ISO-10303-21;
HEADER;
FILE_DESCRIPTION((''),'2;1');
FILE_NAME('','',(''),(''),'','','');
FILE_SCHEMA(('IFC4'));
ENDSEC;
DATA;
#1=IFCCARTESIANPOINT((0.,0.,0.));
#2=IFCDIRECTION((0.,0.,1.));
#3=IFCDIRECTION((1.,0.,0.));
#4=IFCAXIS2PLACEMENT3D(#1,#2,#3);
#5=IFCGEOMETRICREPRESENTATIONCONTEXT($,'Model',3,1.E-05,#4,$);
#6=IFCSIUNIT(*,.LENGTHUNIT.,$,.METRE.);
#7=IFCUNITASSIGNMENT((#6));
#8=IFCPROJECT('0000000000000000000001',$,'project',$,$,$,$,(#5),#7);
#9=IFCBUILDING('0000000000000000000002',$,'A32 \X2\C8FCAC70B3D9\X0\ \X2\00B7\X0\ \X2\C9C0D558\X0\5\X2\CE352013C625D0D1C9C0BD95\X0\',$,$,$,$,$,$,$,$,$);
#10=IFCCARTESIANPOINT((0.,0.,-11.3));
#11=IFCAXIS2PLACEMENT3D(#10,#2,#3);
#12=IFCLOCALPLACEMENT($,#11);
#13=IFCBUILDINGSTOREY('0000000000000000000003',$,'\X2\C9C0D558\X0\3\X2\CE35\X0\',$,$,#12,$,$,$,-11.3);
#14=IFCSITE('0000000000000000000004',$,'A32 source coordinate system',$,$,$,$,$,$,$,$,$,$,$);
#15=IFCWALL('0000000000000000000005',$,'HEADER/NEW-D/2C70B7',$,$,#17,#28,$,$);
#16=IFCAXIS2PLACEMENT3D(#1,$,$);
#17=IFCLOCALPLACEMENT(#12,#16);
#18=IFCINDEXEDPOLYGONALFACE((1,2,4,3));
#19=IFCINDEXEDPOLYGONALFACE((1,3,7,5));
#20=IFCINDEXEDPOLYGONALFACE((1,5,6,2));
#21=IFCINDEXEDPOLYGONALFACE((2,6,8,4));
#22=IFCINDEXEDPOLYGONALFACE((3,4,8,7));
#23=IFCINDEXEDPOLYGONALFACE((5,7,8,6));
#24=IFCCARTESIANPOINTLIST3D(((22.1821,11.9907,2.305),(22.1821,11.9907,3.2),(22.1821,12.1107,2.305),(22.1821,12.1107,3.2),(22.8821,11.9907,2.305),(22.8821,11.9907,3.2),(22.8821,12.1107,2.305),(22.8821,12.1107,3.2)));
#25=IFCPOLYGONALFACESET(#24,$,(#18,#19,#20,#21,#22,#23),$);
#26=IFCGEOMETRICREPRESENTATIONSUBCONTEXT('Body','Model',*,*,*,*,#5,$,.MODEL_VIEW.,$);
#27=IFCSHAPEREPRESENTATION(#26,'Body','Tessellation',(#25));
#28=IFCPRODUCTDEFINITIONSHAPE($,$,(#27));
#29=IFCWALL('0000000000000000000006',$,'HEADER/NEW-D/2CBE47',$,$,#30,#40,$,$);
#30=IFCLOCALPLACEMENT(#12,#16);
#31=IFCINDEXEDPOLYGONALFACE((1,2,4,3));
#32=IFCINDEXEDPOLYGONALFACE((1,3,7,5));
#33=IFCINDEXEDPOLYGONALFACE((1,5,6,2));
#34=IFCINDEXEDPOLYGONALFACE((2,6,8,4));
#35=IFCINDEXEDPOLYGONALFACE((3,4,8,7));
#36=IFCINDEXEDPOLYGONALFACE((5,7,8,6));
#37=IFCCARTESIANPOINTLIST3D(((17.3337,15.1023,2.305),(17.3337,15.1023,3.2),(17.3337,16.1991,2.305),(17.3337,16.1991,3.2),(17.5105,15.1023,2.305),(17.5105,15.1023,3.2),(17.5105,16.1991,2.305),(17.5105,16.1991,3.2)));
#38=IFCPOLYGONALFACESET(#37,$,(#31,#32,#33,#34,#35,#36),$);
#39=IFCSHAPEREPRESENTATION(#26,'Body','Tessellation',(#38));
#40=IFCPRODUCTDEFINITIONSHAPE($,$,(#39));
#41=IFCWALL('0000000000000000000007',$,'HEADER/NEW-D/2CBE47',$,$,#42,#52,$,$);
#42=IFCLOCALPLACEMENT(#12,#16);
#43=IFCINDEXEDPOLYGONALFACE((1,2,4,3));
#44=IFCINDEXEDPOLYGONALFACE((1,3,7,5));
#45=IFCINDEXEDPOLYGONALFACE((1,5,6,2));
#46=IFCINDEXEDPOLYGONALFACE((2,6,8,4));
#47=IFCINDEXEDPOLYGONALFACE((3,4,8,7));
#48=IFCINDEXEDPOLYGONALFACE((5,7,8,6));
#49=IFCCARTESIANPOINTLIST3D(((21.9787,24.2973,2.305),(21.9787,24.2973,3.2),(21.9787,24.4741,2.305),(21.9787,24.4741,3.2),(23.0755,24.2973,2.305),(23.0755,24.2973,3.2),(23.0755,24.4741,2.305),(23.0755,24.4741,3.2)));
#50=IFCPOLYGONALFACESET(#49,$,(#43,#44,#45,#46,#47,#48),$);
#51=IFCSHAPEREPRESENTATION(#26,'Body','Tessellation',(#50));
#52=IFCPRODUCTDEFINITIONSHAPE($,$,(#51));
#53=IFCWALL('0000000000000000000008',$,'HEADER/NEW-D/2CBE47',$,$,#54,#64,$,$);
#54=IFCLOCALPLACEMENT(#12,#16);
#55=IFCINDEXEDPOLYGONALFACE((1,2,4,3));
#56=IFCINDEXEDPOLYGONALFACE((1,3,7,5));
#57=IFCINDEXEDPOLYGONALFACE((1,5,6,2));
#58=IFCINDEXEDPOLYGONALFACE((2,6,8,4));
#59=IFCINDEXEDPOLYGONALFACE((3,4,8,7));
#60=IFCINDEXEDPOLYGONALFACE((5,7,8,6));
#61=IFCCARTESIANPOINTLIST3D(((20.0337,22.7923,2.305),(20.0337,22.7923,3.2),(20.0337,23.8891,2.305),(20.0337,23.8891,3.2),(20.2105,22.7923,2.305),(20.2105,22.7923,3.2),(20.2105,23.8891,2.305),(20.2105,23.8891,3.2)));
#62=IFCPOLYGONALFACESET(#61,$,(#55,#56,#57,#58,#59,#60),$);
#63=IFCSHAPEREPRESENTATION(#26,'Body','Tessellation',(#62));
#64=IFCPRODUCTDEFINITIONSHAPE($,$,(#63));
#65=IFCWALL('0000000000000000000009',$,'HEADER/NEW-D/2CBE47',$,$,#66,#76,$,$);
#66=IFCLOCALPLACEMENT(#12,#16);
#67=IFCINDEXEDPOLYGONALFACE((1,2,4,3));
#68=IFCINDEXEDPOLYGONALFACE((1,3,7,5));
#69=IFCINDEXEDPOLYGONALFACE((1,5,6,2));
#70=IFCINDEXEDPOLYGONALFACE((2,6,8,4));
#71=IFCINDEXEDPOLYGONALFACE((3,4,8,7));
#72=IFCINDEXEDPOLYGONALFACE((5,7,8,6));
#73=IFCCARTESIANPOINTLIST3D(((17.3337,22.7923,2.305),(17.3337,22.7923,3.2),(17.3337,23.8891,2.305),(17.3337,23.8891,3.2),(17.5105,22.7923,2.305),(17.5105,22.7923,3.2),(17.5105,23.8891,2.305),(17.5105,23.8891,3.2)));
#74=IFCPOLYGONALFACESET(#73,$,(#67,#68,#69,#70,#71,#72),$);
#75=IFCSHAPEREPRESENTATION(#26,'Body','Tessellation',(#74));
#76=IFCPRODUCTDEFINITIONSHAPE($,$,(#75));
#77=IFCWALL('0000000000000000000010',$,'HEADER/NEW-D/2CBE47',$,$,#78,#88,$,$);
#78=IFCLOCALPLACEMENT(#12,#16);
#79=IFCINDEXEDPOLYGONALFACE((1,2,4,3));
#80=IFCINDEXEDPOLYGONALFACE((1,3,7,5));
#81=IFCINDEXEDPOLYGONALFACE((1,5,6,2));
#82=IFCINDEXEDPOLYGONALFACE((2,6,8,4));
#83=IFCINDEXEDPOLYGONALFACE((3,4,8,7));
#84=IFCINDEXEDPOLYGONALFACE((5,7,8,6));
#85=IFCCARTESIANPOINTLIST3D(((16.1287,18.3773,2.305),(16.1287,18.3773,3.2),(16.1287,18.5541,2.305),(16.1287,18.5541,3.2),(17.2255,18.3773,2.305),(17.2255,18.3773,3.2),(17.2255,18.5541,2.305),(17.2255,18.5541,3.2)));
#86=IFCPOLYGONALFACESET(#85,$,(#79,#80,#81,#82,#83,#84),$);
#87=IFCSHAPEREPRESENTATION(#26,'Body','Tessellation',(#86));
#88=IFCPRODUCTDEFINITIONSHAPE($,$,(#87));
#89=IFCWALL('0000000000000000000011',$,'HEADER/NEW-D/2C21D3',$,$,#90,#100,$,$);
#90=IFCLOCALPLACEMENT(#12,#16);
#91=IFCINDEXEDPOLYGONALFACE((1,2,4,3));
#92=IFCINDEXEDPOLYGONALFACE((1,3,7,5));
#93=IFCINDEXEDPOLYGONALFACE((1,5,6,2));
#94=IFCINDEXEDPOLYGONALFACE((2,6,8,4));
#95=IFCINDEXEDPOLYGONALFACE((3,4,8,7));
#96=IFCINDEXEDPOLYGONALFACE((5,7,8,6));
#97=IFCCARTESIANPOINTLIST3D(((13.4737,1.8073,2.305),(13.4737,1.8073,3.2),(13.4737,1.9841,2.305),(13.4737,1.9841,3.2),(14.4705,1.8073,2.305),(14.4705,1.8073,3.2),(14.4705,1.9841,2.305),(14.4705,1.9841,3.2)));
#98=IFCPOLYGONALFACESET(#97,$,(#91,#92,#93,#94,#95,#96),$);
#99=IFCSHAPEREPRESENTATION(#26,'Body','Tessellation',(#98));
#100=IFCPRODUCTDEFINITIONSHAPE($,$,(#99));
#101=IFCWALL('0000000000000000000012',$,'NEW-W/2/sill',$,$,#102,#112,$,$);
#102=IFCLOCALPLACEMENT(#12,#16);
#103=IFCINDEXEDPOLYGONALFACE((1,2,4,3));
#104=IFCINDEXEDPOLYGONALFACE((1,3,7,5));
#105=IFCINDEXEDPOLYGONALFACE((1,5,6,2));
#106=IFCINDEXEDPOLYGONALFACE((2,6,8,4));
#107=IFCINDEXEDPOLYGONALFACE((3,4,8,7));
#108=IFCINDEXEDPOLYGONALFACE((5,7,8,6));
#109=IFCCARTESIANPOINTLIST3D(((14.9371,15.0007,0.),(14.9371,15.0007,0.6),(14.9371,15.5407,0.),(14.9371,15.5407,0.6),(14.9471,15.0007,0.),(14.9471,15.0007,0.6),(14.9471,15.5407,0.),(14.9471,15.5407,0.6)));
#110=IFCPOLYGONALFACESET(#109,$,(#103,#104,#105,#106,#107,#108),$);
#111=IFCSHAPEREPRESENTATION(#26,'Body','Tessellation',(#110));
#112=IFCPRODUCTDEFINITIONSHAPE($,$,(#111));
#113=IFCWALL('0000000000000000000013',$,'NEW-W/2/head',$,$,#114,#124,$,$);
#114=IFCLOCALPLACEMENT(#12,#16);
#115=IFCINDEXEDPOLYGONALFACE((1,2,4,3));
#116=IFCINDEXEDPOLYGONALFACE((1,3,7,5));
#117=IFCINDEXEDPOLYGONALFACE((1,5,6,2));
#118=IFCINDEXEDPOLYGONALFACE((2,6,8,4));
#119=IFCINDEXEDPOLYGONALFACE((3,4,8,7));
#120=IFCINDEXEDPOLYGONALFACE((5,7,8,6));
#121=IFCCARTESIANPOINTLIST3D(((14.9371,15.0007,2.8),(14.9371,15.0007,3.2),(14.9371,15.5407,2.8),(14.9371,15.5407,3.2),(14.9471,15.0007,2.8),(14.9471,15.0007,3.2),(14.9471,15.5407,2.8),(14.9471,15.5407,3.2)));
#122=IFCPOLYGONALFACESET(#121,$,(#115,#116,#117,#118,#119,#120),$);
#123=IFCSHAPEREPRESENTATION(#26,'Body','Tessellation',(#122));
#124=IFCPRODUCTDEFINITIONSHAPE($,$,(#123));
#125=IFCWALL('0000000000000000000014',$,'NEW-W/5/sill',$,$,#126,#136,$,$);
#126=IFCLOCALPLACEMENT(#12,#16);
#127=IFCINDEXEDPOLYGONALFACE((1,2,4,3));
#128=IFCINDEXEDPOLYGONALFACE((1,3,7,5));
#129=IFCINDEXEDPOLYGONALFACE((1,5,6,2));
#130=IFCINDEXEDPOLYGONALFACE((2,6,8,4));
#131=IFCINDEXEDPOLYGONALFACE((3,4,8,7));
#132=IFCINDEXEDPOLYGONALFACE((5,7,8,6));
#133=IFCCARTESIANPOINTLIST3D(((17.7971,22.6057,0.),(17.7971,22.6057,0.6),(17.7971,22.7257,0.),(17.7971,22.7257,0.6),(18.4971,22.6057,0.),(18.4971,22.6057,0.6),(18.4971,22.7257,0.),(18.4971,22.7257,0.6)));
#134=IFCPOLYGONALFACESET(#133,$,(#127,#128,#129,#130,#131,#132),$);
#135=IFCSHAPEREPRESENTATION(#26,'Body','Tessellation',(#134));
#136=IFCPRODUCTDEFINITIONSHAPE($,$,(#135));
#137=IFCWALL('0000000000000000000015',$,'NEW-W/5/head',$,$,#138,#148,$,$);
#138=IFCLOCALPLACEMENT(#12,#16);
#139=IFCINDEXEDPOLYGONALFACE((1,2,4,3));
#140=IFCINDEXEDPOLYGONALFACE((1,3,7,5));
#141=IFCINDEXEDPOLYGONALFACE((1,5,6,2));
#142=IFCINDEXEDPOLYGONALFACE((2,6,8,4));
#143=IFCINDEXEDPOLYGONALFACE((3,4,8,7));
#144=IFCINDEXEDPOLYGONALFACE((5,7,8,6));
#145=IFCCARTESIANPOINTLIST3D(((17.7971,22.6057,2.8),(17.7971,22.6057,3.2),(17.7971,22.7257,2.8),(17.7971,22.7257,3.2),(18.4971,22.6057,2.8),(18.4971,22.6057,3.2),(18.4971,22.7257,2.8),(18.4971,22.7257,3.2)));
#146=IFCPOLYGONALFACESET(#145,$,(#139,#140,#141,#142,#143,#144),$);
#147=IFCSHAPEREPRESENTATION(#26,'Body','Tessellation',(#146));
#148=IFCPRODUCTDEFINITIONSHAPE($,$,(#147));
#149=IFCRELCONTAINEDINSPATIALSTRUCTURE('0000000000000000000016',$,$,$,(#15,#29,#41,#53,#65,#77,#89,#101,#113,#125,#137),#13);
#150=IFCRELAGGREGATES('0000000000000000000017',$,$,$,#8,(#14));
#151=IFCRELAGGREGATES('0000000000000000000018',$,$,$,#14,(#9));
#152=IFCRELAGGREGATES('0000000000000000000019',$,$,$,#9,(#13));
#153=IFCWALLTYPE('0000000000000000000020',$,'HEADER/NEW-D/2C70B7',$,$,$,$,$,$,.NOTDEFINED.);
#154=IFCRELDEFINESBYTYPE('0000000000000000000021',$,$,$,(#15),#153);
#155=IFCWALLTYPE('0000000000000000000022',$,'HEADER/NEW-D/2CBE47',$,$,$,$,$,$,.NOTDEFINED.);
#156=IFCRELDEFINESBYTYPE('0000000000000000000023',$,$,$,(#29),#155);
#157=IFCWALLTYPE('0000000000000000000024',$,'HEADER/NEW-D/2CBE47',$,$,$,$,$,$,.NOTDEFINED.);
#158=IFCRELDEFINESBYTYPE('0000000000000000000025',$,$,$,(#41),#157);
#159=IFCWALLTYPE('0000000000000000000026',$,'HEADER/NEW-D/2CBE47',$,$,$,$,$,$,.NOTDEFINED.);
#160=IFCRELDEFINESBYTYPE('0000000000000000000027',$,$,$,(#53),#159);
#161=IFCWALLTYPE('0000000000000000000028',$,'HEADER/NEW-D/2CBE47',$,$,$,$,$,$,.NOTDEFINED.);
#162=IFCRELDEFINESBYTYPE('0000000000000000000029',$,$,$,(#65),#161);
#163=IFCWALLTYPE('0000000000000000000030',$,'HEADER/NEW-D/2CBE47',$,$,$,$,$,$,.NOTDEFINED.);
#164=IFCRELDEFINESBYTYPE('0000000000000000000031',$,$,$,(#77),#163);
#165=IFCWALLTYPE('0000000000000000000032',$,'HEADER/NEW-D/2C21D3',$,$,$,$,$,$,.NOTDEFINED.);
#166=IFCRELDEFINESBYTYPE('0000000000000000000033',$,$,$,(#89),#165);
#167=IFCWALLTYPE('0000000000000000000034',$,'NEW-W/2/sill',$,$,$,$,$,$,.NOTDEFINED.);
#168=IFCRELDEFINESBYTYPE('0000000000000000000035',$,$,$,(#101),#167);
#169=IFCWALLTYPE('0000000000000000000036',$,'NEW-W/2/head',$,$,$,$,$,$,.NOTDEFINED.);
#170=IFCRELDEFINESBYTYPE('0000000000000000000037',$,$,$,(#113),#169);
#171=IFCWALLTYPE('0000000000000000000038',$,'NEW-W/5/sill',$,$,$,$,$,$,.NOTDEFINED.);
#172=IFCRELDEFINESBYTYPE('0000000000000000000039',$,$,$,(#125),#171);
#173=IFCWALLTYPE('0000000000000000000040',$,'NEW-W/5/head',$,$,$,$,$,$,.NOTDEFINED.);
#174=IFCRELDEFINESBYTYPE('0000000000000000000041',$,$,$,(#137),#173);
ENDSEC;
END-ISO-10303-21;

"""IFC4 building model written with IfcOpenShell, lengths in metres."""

from ifc_helpers import new_model, si_unit, frame, origin, origin_with_axes, place, context, subcontext, project, spatial, polyline, outline, extrude, source, transform, mapped, type_object, type_shapes, element, save


model = new_model("IFC4")

# Units and contexts
model_context = context("Model", 3, precision=1e-05, world=origin_with_axes())
body_context = subcontext(model_context, "Body", "Model", "MODEL_VIEW")
ifc_project = project(units=[si_unit("LENGTHUNIT", "METRE")], contexts=[model_context])

# Site, building, storey
site = spatial("IfcSite", under=ifc_project, Name="A32 source coordinate system")
building = spatial("IfcBuilding", under=site, Name="A32 주거동 · 지하5층–옥탑지붕")
storey_placement = place(None, frame((0.0, 0.0, -11.3), z_axis=(0.0, 0.0, 1.0), x_axis=(1.0, 0.0, 0.0)))
storey = spatial("IfcBuildingStorey", under=building, at=storey_placement, Name="지하3층", Elevation=-11.3)

# Walls
wall_type_1 = type_object("IfcWallType", Name="HEADER/NEW-D/2C70B7", PredefinedType="NOTDEFINED")
shared_shape_1 = source(origin(), body_context, "Body", "SweptSolid", [
    extrude(outline(polyline([(22.1821, 11.9907), (22.1821, 12.1107), (22.8821, 12.1107), (22.8821, 11.9907), (22.1821, 11.9907)])), frame((0.0, 0.0, 2.305)), (0.0, 0.0, 1.0), 0.895),
])
type_shapes(wall_type_1, [shared_shape_1])
wall_1_placement = place(storey_placement, origin_with_axes())
element("IfcWall", 1, at=wall_1_placement, inside=storey, type_object=wall_type_1, Name="HEADER/NEW-D/2C70B7", context=body_context, shape_type="MappedRepresentation", body=[
    mapped(shared_shape_1, transform((0.0, 0.0, 0.0), scale=1.0)),
])
wall_type_2 = type_object("IfcWallType", Name="HEADER/NEW-D/2CBE47", PredefinedType="NOTDEFINED")
shared_shape_2 = source(origin(), body_context, "Body", "SweptSolid", [
    extrude(outline(polyline([(17.3337, 15.1023), (17.3337, 16.1991), (17.5105, 16.1991), (17.5105, 15.1023), (17.3337, 15.1023)])), frame((0.0, 0.0, 2.305)), (0.0, 0.0, 1.0), 0.895),
])
type_shapes(wall_type_2, [shared_shape_2])
wall_2_placement = place(storey_placement, origin_with_axes())
element("IfcWall", 2, at=wall_2_placement, inside=storey, type_object=wall_type_2, Name="HEADER/NEW-D/2CBE47", context=body_context, shape_type="MappedRepresentation", body=[
    mapped(shared_shape_2, transform((0.0, 0.0, 0.0), scale=1.0)),
])
wall_type_3 = type_object("IfcWallType", Name="HEADER/NEW-D/2CBE47", PredefinedType="NOTDEFINED")
shared_shape_3 = source(origin(), body_context, "Body", "SweptSolid", [
    extrude(outline(polyline([(21.9787, 24.2973), (21.9787, 24.4741), (23.0755, 24.4741), (23.0755, 24.2973), (21.9787, 24.2973)])), frame((0.0, 0.0, 2.305)), (0.0, 0.0, 1.0), 0.895),
])
type_shapes(wall_type_3, [shared_shape_3])
wall_3_placement = place(storey_placement, origin_with_axes())
element("IfcWall", 3, at=wall_3_placement, inside=storey, type_object=wall_type_3, Name="HEADER/NEW-D/2CBE47", context=body_context, shape_type="MappedRepresentation", body=[
    mapped(shared_shape_3, transform((0.0, 0.0, 0.0), scale=1.0)),
])
wall_type_4 = type_object("IfcWallType", Name="HEADER/NEW-D/2CBE47", PredefinedType="NOTDEFINED")
shared_shape_4 = source(origin(), body_context, "Body", "SweptSolid", [
    extrude(outline(polyline([(20.0337, 22.7923), (20.0337, 23.8891), (20.2105, 23.8891), (20.2105, 22.7923), (20.0337, 22.7923)])), frame((0.0, 0.0, 2.305)), (0.0, 0.0, 1.0), 0.895),
])
type_shapes(wall_type_4, [shared_shape_4])
wall_4_placement = place(storey_placement, origin_with_axes())
element("IfcWall", 4, at=wall_4_placement, inside=storey, type_object=wall_type_4, Name="HEADER/NEW-D/2CBE47", context=body_context, shape_type="MappedRepresentation", body=[
    mapped(shared_shape_4, transform((0.0, 0.0, 0.0), scale=1.0)),
])
wall_type_5 = type_object("IfcWallType", Name="HEADER/NEW-D/2CBE47", PredefinedType="NOTDEFINED")
shared_shape_5 = source(origin(), body_context, "Body", "SweptSolid", [
    extrude(outline(polyline([(17.3337, 22.7923), (17.3337, 23.8891), (17.5105, 23.8891), (17.5105, 22.7923), (17.3337, 22.7923)])), frame((0.0, 0.0, 2.305)), (0.0, 0.0, 1.0), 0.895),
])
type_shapes(wall_type_5, [shared_shape_5])
wall_5_placement = place(storey_placement, origin_with_axes())
element("IfcWall", 5, at=wall_5_placement, inside=storey, type_object=wall_type_5, Name="HEADER/NEW-D/2CBE47", context=body_context, shape_type="MappedRepresentation", body=[
    mapped(shared_shape_5, transform((0.0, 0.0, 0.0), scale=1.0)),
])
wall_type_6 = type_object("IfcWallType", Name="HEADER/NEW-D/2CBE47", PredefinedType="NOTDEFINED")
shared_shape_6 = source(origin(), body_context, "Body", "SweptSolid", [
    extrude(outline(polyline([(16.1287, 18.3773), (16.1287, 18.5541), (17.2255, 18.5541), (17.2255, 18.3773), (16.1287, 18.3773)])), frame((0.0, 0.0, 2.305)), (0.0, 0.0, 1.0), 0.895),
])
type_shapes(wall_type_6, [shared_shape_6])
wall_6_placement = place(storey_placement, origin_with_axes())
element("IfcWall", 6, at=wall_6_placement, inside=storey, type_object=wall_type_6, Name="HEADER/NEW-D/2CBE47", context=body_context, shape_type="MappedRepresentation", body=[
    mapped(shared_shape_6, transform((0.0, 0.0, 0.0), scale=1.0)),
])
wall_type_7 = type_object("IfcWallType", Name="HEADER/NEW-D/2C21D3", PredefinedType="NOTDEFINED")
shared_shape_7 = source(origin(), body_context, "Body", "SweptSolid", [
    extrude(outline(polyline([(13.4737, 1.8073), (13.4737, 1.9841), (14.4705, 1.9841), (14.4705, 1.8073), (13.4737, 1.8073)])), frame((0.0, 0.0, 2.305)), (0.0, 0.0, 1.0), 0.895),
])
type_shapes(wall_type_7, [shared_shape_7])
wall_7_placement = place(storey_placement, origin_with_axes())
element("IfcWall", 7, at=wall_7_placement, inside=storey, type_object=wall_type_7, Name="HEADER/NEW-D/2C21D3", context=body_context, shape_type="MappedRepresentation", body=[
    mapped(shared_shape_7, transform((0.0, 0.0, 0.0), scale=1.0)),
])
wall_type_8 = type_object("IfcWallType", Name="NEW-W/2/sill", PredefinedType="NOTDEFINED")
shared_shape_8 = source(origin(), body_context, "Body", "SweptSolid", [
    extrude(outline(polyline([(14.9471, 15.5407), (14.9471, 15.0007), (14.9371, 15.0007), (14.9371, 15.5407), (14.9471, 15.5407)])), origin(), (0.0, 0.0, 1.0), 0.6),
])
type_shapes(wall_type_8, [shared_shape_8])
wall_8_placement = place(storey_placement, origin_with_axes())
element("IfcWall", 8, at=wall_8_placement, inside=storey, type_object=wall_type_8, Name="NEW-W/2/sill", context=body_context, shape_type="MappedRepresentation", body=[
    mapped(shared_shape_8, transform((0.0, 0.0, 0.0), scale=1.0)),
])
wall_type_9 = type_object("IfcWallType", Name="NEW-W/2/head", PredefinedType="NOTDEFINED")
shared_shape_9 = source(origin(), body_context, "Body", "SweptSolid", [
    extrude(outline(polyline([(14.9471, 15.5407), (14.9471, 15.0007), (14.9371, 15.0007), (14.9371, 15.5407), (14.9471, 15.5407)])), frame((0.0, 0.0, 2.8)), (0.0, 0.0, 1.0), 0.4),
])
type_shapes(wall_type_9, [shared_shape_9])
wall_9_placement = place(storey_placement, origin_with_axes())
element("IfcWall", 9, at=wall_9_placement, inside=storey, type_object=wall_type_9, Name="NEW-W/2/head", context=body_context, shape_type="MappedRepresentation", body=[
    mapped(shared_shape_9, transform((0.0, 0.0, 0.0), scale=1.0)),
])
wall_type_10 = type_object("IfcWallType", Name="NEW-W/5/sill", PredefinedType="NOTDEFINED")
shared_shape_10 = source(origin(), body_context, "Body", "SweptSolid", [
    extrude(outline(polyline([(17.7971, 22.6057), (17.7971, 22.7257), (18.4971, 22.7257), (18.4971, 22.6057), (17.7971, 22.6057)])), origin(), (0.0, 0.0, 1.0), 0.6),
])
type_shapes(wall_type_10, [shared_shape_10])
wall_10_placement = place(storey_placement, origin_with_axes())
element("IfcWall", 10, at=wall_10_placement, inside=storey, type_object=wall_type_10, Name="NEW-W/5/sill", context=body_context, shape_type="MappedRepresentation", body=[
    mapped(shared_shape_10, transform((0.0, 0.0, 0.0), scale=1.0)),
])
wall_type_11 = type_object("IfcWallType", Name="NEW-W/5/head", PredefinedType="NOTDEFINED")
shared_shape_11 = source(origin(), body_context, "Body", "SweptSolid", [
    extrude(outline(polyline([(17.7971, 22.6057), (17.7971, 22.7257), (18.4971, 22.7257), (18.4971, 22.6057), (17.7971, 22.6057)])), frame((0.0, 0.0, 2.8)), (0.0, 0.0, 1.0), 0.4),
])
type_shapes(wall_type_11, [shared_shape_11])
wall_11_placement = place(storey_placement, origin_with_axes())
element("IfcWall", 11, at=wall_11_placement, inside=storey, type_object=wall_type_11, Name="NEW-W/5/head", context=body_context, shape_type="MappedRepresentation", body=[
    mapped(shared_shape_11, transform((0.0, 0.0, 0.0), scale=1.0)),
])

save(model, "model.ifc")
